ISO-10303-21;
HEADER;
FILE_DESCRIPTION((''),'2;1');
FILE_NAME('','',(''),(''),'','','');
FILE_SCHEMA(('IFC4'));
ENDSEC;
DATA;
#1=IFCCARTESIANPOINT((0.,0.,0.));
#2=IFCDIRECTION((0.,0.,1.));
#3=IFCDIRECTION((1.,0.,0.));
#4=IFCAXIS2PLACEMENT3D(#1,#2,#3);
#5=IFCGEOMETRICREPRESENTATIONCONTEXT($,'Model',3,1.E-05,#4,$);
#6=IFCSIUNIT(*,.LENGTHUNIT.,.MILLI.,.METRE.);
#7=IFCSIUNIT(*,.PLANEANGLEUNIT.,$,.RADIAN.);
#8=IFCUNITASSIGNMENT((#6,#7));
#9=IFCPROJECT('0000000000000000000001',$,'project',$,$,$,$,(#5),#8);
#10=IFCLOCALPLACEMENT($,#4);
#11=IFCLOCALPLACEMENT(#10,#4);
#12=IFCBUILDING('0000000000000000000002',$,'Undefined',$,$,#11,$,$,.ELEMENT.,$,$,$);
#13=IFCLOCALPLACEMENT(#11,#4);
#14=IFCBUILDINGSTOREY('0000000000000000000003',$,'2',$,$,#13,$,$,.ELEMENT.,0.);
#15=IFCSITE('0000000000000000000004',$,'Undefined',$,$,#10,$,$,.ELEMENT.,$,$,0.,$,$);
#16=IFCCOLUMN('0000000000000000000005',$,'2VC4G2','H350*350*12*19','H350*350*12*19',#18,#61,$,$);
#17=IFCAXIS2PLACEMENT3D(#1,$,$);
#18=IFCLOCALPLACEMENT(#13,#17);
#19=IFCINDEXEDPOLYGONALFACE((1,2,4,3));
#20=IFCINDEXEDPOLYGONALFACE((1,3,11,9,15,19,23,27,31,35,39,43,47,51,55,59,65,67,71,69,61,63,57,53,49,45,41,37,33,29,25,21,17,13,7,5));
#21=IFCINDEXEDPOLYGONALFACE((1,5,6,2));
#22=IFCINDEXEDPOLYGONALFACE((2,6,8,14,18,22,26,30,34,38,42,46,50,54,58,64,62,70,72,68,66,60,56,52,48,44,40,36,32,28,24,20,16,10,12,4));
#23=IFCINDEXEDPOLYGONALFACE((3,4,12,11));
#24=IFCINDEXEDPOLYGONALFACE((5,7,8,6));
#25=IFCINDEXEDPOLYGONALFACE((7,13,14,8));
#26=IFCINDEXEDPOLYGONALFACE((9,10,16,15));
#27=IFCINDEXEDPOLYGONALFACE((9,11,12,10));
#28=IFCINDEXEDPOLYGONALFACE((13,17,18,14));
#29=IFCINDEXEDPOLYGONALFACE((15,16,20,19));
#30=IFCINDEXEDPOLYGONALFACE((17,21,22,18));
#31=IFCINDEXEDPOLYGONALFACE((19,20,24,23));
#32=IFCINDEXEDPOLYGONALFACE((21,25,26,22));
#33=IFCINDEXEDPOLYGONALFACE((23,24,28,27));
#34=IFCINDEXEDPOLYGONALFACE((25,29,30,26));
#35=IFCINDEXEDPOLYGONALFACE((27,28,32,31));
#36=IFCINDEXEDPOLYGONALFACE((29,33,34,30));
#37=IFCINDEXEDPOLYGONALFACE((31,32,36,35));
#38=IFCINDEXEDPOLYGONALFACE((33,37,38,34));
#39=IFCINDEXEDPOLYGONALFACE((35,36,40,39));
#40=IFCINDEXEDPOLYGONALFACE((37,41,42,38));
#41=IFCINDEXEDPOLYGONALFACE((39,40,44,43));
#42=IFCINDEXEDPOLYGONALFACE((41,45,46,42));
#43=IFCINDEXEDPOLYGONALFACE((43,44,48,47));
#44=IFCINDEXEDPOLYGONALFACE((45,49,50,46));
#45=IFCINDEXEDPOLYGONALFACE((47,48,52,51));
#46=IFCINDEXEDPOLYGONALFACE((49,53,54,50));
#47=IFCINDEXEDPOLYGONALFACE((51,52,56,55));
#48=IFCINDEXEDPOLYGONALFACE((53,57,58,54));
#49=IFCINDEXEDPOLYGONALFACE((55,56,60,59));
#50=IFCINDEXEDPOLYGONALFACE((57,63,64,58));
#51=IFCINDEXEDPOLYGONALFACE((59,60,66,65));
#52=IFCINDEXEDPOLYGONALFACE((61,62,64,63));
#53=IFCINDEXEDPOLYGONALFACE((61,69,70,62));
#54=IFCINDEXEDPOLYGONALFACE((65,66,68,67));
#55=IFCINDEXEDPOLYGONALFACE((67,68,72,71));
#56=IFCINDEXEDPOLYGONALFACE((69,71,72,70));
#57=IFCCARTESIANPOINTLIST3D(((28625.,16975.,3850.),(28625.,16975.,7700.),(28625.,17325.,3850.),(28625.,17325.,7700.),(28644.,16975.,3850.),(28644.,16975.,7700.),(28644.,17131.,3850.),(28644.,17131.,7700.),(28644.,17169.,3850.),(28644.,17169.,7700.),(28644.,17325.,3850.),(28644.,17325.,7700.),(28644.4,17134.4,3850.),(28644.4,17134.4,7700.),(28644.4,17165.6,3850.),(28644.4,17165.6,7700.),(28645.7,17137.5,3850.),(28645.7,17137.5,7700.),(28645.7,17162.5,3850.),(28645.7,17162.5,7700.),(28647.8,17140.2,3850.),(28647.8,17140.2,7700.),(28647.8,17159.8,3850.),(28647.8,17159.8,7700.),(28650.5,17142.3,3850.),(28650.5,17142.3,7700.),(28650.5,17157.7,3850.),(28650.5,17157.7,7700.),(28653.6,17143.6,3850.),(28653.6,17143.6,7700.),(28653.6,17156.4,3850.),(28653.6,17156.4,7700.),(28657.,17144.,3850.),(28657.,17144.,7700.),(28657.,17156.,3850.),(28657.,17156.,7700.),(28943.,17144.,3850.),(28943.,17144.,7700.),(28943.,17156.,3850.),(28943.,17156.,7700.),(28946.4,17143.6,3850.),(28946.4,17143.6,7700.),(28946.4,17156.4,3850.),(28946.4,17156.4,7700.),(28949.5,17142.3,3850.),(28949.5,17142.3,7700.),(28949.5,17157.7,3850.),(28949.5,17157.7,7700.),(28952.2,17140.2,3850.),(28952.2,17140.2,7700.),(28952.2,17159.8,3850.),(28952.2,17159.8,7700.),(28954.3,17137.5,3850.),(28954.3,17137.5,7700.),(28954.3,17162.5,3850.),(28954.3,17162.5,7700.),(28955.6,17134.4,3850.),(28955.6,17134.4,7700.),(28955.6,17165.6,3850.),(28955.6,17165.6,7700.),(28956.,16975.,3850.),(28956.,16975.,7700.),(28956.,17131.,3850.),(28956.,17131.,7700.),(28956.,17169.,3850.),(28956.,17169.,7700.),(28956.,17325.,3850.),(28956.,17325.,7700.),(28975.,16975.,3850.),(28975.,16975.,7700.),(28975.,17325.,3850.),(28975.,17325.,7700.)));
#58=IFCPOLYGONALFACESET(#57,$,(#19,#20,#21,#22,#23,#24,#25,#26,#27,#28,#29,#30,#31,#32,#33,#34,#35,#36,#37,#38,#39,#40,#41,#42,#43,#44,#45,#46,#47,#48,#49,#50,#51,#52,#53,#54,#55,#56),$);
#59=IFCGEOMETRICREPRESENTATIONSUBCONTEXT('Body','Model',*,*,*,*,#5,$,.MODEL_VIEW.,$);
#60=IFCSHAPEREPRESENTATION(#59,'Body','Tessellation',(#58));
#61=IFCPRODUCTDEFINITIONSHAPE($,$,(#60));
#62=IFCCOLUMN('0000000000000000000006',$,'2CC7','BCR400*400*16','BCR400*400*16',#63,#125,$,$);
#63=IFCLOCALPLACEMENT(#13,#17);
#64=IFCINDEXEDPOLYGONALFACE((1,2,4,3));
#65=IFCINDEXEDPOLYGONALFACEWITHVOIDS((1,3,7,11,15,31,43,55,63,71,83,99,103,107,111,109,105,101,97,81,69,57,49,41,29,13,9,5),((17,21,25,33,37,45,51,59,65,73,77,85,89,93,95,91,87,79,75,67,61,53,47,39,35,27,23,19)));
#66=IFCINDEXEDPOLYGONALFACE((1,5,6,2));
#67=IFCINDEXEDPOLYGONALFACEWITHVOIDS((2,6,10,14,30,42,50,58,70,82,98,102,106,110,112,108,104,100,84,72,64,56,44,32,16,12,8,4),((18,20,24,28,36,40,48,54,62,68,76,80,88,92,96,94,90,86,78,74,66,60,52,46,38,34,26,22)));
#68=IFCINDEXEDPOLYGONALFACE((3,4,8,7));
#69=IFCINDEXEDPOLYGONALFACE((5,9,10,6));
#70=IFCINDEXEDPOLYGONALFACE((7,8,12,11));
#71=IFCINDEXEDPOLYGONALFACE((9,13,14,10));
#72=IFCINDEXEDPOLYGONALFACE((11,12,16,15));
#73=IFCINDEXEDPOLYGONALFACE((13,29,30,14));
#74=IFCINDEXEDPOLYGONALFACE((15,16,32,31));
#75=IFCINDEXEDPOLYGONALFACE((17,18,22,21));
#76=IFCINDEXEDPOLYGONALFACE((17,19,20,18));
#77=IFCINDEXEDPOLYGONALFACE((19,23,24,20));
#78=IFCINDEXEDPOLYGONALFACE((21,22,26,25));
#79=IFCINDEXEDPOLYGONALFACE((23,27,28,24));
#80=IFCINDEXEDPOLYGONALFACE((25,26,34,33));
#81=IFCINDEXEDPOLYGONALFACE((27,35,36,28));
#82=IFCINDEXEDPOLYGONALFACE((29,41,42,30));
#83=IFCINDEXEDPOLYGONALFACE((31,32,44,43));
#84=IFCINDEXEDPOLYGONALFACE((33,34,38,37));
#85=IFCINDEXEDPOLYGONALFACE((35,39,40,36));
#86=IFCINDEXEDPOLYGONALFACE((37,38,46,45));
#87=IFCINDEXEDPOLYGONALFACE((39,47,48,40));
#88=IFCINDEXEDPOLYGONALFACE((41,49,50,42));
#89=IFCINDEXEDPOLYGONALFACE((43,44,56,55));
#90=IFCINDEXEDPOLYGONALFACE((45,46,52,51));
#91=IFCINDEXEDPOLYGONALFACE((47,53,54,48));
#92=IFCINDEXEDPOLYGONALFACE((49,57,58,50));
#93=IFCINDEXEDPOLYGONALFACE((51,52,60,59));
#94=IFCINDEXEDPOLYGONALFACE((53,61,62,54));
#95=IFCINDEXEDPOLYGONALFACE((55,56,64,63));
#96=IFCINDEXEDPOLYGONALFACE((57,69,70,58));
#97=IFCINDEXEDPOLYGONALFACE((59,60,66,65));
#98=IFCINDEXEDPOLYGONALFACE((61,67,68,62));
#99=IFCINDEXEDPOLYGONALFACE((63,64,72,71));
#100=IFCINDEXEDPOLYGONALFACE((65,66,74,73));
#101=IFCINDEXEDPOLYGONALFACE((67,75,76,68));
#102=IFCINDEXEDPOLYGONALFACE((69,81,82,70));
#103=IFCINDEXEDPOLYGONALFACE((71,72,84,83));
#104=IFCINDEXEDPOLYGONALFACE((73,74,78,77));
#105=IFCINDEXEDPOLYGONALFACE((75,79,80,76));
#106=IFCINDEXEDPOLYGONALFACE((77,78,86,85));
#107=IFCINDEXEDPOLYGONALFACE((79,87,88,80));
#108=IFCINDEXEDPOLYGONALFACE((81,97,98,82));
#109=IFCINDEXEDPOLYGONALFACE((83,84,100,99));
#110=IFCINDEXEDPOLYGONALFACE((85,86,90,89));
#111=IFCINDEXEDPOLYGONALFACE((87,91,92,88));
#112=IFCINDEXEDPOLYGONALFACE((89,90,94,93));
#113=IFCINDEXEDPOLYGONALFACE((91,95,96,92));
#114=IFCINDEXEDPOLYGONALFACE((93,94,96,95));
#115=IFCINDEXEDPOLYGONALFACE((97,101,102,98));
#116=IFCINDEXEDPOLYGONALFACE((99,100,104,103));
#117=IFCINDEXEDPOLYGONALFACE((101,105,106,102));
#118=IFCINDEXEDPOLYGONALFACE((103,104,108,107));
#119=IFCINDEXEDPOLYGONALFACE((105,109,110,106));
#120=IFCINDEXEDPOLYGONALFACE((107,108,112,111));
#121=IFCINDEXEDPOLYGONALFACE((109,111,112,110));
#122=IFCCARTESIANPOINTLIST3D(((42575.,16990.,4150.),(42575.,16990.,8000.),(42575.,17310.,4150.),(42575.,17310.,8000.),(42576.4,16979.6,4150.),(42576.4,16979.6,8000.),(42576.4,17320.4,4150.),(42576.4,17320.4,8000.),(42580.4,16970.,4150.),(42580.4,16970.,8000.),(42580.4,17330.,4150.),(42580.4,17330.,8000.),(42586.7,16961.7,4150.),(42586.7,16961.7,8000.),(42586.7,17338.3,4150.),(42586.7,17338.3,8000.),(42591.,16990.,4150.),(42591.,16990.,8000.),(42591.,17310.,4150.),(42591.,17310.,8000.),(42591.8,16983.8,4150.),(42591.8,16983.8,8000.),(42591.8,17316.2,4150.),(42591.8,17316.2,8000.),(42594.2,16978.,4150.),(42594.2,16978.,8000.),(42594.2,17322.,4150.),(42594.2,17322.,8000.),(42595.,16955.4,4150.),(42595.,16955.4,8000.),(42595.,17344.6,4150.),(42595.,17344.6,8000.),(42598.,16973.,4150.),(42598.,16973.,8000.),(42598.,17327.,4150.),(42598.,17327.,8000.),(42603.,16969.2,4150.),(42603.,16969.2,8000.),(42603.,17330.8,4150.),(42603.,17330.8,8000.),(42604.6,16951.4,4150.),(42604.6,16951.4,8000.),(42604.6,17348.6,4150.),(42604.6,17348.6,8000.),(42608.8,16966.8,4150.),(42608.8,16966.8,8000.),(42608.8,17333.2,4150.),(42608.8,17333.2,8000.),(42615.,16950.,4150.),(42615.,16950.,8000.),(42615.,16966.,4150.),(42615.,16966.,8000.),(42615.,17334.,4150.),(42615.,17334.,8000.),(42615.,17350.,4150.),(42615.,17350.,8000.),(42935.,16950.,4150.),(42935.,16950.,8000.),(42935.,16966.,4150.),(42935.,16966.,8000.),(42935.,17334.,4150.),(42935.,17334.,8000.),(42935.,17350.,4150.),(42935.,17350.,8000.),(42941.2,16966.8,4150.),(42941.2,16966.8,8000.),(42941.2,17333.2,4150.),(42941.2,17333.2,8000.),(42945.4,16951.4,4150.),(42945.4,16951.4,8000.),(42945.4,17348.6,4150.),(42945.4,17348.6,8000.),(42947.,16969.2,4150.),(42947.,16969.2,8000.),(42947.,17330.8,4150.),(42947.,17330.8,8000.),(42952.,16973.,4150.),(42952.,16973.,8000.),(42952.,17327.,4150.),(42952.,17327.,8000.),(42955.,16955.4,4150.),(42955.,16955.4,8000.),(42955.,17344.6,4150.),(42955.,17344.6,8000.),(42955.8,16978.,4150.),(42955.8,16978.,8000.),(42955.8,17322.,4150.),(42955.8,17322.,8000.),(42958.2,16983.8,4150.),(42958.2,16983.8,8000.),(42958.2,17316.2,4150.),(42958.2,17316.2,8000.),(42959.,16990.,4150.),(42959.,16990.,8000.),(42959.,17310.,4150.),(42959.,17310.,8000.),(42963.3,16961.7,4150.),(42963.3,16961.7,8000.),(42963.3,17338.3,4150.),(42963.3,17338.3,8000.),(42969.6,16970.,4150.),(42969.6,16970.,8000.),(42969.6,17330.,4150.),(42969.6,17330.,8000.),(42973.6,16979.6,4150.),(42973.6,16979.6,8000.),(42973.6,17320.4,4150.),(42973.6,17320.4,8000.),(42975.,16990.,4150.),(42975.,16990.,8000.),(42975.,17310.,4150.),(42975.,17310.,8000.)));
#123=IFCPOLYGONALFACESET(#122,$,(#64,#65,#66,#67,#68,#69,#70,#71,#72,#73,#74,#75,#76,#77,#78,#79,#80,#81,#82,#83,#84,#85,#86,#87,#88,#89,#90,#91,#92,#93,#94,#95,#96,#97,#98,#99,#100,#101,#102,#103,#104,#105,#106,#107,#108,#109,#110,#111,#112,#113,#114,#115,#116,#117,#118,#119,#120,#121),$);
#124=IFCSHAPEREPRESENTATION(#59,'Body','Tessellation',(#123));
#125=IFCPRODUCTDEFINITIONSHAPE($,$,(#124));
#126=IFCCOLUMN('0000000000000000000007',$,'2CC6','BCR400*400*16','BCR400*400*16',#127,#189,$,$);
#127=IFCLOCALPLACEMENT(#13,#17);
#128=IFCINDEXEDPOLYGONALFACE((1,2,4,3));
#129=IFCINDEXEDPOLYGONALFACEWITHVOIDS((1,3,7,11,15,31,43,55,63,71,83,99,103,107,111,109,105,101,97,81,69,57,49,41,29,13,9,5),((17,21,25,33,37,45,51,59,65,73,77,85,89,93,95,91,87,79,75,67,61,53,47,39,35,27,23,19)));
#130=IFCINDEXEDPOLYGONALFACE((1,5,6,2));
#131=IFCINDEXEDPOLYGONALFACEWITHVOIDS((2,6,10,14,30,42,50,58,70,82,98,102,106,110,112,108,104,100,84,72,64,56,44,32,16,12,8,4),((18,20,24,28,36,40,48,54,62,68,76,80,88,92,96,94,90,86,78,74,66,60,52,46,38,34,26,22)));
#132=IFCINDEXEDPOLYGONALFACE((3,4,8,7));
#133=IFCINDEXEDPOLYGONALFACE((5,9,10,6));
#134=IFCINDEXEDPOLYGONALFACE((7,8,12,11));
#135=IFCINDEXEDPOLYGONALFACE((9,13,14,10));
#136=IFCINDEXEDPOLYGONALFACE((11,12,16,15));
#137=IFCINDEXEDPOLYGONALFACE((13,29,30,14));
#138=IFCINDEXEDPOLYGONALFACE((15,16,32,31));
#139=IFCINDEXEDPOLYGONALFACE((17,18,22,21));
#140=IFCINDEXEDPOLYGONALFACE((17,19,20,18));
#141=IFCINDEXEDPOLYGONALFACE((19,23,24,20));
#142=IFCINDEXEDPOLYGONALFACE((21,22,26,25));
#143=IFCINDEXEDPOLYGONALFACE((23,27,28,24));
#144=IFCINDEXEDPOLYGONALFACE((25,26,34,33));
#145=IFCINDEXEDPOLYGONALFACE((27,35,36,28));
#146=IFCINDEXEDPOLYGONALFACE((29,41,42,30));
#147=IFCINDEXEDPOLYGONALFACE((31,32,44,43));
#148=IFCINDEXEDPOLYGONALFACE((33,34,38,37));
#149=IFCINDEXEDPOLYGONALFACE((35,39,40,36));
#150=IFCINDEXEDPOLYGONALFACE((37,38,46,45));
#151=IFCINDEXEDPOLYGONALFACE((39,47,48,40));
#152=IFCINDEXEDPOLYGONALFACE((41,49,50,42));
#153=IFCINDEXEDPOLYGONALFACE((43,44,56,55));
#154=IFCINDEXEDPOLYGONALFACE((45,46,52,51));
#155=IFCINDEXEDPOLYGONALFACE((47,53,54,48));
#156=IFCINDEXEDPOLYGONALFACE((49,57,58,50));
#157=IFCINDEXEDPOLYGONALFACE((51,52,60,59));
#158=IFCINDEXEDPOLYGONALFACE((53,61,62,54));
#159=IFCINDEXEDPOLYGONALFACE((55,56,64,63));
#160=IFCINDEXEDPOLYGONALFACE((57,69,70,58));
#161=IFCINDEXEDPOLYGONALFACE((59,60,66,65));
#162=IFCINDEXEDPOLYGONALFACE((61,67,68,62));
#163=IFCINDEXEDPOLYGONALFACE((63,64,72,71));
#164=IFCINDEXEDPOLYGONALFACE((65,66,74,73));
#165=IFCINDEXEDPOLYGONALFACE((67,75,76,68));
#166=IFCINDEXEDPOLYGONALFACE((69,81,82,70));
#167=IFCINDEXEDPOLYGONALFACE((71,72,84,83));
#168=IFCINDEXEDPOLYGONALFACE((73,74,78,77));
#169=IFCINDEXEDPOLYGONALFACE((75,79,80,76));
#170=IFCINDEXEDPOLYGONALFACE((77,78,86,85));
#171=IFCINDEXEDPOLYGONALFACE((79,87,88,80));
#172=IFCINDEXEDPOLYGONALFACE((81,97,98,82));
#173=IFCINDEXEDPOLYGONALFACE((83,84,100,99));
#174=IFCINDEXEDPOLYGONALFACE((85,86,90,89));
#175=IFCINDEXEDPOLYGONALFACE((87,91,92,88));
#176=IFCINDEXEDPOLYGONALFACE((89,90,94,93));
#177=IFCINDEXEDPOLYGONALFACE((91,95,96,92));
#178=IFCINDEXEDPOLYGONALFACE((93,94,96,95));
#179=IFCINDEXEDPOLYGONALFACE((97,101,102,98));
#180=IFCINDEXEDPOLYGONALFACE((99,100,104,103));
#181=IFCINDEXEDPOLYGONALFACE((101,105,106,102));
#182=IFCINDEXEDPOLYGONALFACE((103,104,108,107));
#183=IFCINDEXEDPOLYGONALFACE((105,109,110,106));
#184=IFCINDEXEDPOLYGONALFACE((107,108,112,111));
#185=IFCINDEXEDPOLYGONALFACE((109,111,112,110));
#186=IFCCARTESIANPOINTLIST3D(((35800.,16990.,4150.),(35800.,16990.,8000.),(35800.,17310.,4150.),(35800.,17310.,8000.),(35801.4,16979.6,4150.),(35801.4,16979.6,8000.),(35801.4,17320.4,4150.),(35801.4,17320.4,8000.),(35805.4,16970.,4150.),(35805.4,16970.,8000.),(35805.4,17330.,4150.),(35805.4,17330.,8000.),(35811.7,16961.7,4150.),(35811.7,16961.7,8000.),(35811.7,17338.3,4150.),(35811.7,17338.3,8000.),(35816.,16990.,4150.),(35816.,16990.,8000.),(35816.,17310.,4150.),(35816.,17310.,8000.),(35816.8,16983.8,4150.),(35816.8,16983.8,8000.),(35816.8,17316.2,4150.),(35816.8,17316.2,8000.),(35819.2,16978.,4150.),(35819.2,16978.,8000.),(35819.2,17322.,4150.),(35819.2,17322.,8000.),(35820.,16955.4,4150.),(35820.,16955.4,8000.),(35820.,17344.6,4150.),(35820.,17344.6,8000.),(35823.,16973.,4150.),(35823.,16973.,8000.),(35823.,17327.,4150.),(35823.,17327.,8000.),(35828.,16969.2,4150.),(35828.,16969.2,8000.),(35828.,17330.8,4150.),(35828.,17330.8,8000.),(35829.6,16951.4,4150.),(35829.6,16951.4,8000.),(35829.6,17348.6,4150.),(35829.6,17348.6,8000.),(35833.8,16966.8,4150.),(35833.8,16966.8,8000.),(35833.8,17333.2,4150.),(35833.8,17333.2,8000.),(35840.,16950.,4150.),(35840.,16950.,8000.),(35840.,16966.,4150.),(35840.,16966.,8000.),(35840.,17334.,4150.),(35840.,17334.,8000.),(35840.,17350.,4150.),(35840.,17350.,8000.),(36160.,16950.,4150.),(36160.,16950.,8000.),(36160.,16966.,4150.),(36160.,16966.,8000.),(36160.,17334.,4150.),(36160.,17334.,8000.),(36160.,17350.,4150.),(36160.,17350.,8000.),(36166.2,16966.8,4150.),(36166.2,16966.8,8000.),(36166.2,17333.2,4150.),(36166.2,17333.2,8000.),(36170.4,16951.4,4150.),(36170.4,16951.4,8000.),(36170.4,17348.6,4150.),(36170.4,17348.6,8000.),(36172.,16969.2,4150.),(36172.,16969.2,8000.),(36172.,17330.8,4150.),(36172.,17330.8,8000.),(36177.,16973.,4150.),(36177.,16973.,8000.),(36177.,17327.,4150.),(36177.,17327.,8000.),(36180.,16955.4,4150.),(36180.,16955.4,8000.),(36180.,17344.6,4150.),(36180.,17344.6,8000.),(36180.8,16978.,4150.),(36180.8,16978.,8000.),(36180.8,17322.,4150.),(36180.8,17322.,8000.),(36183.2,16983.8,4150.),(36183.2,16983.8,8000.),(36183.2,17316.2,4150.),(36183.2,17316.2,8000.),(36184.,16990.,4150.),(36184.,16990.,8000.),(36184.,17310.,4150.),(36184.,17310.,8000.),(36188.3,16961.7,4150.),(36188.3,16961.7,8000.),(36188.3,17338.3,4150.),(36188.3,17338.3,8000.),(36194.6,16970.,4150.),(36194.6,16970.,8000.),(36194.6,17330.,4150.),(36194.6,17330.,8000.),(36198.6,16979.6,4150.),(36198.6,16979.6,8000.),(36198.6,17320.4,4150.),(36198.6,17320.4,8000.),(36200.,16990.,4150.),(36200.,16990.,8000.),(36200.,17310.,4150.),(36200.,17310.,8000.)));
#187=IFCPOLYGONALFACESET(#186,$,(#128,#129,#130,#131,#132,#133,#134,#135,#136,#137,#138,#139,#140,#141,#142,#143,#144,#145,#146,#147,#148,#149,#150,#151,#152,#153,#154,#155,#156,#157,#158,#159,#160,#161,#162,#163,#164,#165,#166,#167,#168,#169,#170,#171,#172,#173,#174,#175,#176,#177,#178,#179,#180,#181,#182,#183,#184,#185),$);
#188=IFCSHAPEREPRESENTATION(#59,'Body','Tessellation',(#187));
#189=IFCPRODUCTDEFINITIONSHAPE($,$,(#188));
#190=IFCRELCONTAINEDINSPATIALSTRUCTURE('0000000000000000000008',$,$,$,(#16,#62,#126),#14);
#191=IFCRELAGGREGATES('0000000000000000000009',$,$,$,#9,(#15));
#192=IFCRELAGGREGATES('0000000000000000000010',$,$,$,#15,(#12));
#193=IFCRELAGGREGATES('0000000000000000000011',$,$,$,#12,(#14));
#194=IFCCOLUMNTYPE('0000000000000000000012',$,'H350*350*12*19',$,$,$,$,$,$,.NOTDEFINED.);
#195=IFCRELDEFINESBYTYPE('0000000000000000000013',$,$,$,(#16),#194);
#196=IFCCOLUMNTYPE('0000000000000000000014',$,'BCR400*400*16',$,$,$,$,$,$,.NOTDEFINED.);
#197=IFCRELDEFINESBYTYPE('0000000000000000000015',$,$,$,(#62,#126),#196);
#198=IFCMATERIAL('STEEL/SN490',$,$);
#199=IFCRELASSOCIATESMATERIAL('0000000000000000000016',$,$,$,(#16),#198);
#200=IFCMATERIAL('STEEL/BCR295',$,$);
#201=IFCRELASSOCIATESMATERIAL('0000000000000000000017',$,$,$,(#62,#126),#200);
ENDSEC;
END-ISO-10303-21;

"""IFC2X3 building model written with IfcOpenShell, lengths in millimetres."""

from ifc_helpers import new_model, si_unit, frame, origin_with_axes, origin_2d_with_axis, place, context, subcontext, project, spatial, hollow_rectangle, i_section, extrude, material, type_object, element, save


model = new_model("IFC2X3")

# Units and contexts
model_context = context("Model", 3, precision=1e-05, world=origin_with_axes())
body_context = subcontext(model_context, "Body", "Model", "MODEL_VIEW")
ifc_project = project(units=[si_unit("LENGTHUNIT", "METRE", prefix="MILLI"), si_unit("PLANEANGLEUNIT", "RADIAN")], contexts=[model_context])

# Site, building, storey
site_placement = place(None, origin_with_axes())
site = spatial("IfcSite", under=ifc_project, at=site_placement, Name="Undefined", CompositionType="ELEMENT", RefElevation=0.0)
building_placement = place(site_placement, origin_with_axes())
building = spatial("IfcBuilding", under=site, at=building_placement, Name="Undefined", CompositionType="ELEMENT")
storey_placement = place(building_placement, origin_with_axes())
storey = spatial("IfcBuildingStorey", under=building, at=storey_placement, Name="2", CompositionType="ELEMENT", Elevation=0.0)

# Columns
ifc_material_1 = material(Name="STEEL/SN490")
column_type_1 = type_object("IfcColumnType", Name="H350*350*12*19", PredefinedType="NOTDEFINED")
column_placement = place(storey_placement, frame((28800.0, 17150.0, 3850.0), z_axis=(0.0, 0.0, 1.0), x_axis=(-1.0, 0.0, 0.0)))
element("IfcColumn", 1, at=column_placement, inside=storey, type_object=column_type_1, material=ifc_material_1, Name="2VC4G2", Description="H350*350*12*19", ObjectType="H350*350*12*19", context=body_context, shape_type="SweptSolid", body=[
    extrude(i_section(OverallWidth=350.0, OverallDepth=350.0, WebThickness=12.0, FlangeThickness=19.0, FilletRadius=13.0, at=origin_2d_with_axis()), frame((0.0, 0.0, 3850.0), z_axis=(0.0, 0.0, -1.0), x_axis=(0.0, 1.0, 0.0)), (0.0, 0.0, 1.0), 3850.0),
])
ifc_material_2 = material(Name="STEEL/BCR295")
column_type_2 = type_object("IfcColumnType", Name="BCR400*400*16", PredefinedType="NOTDEFINED")
for number, where, z_axis, x_axis, name in (
    (2, (42775.0, 17150.0, 4150.0), (0.0, 0.0, 1.0), (0.0, 1.0, 0.0), "2CC7"),
    (3, (36000.0, 17150.0, 4150.0), (0.0, 0.0, 1.0), (0.0, 1.0, 0.0), "2CC6"),
):
    element("IfcColumn", number, at=place(storey_placement, frame(where, z_axis=z_axis, x_axis=x_axis)), inside=storey, type_object=column_type_2, material=ifc_material_2, Name=name, Description="BCR400*400*16", ObjectType="BCR400*400*16", context=body_context, shape_type="SweptSolid", body=[
        extrude(hollow_rectangle(XDim=400.0, YDim=400.0, WallThickness=16.0, InnerFilletRadius=24.0, OuterFilletRadius=40.0, at=origin_2d_with_axis()), frame((0.0, 0.0, 3850.0), z_axis=(0.0, 0.0, -1.0), x_axis=(0.0, 1.0, 0.0)), (0.0, 0.0, 1.0), 3850.0),
    ])

save(model, "model.ifc")
